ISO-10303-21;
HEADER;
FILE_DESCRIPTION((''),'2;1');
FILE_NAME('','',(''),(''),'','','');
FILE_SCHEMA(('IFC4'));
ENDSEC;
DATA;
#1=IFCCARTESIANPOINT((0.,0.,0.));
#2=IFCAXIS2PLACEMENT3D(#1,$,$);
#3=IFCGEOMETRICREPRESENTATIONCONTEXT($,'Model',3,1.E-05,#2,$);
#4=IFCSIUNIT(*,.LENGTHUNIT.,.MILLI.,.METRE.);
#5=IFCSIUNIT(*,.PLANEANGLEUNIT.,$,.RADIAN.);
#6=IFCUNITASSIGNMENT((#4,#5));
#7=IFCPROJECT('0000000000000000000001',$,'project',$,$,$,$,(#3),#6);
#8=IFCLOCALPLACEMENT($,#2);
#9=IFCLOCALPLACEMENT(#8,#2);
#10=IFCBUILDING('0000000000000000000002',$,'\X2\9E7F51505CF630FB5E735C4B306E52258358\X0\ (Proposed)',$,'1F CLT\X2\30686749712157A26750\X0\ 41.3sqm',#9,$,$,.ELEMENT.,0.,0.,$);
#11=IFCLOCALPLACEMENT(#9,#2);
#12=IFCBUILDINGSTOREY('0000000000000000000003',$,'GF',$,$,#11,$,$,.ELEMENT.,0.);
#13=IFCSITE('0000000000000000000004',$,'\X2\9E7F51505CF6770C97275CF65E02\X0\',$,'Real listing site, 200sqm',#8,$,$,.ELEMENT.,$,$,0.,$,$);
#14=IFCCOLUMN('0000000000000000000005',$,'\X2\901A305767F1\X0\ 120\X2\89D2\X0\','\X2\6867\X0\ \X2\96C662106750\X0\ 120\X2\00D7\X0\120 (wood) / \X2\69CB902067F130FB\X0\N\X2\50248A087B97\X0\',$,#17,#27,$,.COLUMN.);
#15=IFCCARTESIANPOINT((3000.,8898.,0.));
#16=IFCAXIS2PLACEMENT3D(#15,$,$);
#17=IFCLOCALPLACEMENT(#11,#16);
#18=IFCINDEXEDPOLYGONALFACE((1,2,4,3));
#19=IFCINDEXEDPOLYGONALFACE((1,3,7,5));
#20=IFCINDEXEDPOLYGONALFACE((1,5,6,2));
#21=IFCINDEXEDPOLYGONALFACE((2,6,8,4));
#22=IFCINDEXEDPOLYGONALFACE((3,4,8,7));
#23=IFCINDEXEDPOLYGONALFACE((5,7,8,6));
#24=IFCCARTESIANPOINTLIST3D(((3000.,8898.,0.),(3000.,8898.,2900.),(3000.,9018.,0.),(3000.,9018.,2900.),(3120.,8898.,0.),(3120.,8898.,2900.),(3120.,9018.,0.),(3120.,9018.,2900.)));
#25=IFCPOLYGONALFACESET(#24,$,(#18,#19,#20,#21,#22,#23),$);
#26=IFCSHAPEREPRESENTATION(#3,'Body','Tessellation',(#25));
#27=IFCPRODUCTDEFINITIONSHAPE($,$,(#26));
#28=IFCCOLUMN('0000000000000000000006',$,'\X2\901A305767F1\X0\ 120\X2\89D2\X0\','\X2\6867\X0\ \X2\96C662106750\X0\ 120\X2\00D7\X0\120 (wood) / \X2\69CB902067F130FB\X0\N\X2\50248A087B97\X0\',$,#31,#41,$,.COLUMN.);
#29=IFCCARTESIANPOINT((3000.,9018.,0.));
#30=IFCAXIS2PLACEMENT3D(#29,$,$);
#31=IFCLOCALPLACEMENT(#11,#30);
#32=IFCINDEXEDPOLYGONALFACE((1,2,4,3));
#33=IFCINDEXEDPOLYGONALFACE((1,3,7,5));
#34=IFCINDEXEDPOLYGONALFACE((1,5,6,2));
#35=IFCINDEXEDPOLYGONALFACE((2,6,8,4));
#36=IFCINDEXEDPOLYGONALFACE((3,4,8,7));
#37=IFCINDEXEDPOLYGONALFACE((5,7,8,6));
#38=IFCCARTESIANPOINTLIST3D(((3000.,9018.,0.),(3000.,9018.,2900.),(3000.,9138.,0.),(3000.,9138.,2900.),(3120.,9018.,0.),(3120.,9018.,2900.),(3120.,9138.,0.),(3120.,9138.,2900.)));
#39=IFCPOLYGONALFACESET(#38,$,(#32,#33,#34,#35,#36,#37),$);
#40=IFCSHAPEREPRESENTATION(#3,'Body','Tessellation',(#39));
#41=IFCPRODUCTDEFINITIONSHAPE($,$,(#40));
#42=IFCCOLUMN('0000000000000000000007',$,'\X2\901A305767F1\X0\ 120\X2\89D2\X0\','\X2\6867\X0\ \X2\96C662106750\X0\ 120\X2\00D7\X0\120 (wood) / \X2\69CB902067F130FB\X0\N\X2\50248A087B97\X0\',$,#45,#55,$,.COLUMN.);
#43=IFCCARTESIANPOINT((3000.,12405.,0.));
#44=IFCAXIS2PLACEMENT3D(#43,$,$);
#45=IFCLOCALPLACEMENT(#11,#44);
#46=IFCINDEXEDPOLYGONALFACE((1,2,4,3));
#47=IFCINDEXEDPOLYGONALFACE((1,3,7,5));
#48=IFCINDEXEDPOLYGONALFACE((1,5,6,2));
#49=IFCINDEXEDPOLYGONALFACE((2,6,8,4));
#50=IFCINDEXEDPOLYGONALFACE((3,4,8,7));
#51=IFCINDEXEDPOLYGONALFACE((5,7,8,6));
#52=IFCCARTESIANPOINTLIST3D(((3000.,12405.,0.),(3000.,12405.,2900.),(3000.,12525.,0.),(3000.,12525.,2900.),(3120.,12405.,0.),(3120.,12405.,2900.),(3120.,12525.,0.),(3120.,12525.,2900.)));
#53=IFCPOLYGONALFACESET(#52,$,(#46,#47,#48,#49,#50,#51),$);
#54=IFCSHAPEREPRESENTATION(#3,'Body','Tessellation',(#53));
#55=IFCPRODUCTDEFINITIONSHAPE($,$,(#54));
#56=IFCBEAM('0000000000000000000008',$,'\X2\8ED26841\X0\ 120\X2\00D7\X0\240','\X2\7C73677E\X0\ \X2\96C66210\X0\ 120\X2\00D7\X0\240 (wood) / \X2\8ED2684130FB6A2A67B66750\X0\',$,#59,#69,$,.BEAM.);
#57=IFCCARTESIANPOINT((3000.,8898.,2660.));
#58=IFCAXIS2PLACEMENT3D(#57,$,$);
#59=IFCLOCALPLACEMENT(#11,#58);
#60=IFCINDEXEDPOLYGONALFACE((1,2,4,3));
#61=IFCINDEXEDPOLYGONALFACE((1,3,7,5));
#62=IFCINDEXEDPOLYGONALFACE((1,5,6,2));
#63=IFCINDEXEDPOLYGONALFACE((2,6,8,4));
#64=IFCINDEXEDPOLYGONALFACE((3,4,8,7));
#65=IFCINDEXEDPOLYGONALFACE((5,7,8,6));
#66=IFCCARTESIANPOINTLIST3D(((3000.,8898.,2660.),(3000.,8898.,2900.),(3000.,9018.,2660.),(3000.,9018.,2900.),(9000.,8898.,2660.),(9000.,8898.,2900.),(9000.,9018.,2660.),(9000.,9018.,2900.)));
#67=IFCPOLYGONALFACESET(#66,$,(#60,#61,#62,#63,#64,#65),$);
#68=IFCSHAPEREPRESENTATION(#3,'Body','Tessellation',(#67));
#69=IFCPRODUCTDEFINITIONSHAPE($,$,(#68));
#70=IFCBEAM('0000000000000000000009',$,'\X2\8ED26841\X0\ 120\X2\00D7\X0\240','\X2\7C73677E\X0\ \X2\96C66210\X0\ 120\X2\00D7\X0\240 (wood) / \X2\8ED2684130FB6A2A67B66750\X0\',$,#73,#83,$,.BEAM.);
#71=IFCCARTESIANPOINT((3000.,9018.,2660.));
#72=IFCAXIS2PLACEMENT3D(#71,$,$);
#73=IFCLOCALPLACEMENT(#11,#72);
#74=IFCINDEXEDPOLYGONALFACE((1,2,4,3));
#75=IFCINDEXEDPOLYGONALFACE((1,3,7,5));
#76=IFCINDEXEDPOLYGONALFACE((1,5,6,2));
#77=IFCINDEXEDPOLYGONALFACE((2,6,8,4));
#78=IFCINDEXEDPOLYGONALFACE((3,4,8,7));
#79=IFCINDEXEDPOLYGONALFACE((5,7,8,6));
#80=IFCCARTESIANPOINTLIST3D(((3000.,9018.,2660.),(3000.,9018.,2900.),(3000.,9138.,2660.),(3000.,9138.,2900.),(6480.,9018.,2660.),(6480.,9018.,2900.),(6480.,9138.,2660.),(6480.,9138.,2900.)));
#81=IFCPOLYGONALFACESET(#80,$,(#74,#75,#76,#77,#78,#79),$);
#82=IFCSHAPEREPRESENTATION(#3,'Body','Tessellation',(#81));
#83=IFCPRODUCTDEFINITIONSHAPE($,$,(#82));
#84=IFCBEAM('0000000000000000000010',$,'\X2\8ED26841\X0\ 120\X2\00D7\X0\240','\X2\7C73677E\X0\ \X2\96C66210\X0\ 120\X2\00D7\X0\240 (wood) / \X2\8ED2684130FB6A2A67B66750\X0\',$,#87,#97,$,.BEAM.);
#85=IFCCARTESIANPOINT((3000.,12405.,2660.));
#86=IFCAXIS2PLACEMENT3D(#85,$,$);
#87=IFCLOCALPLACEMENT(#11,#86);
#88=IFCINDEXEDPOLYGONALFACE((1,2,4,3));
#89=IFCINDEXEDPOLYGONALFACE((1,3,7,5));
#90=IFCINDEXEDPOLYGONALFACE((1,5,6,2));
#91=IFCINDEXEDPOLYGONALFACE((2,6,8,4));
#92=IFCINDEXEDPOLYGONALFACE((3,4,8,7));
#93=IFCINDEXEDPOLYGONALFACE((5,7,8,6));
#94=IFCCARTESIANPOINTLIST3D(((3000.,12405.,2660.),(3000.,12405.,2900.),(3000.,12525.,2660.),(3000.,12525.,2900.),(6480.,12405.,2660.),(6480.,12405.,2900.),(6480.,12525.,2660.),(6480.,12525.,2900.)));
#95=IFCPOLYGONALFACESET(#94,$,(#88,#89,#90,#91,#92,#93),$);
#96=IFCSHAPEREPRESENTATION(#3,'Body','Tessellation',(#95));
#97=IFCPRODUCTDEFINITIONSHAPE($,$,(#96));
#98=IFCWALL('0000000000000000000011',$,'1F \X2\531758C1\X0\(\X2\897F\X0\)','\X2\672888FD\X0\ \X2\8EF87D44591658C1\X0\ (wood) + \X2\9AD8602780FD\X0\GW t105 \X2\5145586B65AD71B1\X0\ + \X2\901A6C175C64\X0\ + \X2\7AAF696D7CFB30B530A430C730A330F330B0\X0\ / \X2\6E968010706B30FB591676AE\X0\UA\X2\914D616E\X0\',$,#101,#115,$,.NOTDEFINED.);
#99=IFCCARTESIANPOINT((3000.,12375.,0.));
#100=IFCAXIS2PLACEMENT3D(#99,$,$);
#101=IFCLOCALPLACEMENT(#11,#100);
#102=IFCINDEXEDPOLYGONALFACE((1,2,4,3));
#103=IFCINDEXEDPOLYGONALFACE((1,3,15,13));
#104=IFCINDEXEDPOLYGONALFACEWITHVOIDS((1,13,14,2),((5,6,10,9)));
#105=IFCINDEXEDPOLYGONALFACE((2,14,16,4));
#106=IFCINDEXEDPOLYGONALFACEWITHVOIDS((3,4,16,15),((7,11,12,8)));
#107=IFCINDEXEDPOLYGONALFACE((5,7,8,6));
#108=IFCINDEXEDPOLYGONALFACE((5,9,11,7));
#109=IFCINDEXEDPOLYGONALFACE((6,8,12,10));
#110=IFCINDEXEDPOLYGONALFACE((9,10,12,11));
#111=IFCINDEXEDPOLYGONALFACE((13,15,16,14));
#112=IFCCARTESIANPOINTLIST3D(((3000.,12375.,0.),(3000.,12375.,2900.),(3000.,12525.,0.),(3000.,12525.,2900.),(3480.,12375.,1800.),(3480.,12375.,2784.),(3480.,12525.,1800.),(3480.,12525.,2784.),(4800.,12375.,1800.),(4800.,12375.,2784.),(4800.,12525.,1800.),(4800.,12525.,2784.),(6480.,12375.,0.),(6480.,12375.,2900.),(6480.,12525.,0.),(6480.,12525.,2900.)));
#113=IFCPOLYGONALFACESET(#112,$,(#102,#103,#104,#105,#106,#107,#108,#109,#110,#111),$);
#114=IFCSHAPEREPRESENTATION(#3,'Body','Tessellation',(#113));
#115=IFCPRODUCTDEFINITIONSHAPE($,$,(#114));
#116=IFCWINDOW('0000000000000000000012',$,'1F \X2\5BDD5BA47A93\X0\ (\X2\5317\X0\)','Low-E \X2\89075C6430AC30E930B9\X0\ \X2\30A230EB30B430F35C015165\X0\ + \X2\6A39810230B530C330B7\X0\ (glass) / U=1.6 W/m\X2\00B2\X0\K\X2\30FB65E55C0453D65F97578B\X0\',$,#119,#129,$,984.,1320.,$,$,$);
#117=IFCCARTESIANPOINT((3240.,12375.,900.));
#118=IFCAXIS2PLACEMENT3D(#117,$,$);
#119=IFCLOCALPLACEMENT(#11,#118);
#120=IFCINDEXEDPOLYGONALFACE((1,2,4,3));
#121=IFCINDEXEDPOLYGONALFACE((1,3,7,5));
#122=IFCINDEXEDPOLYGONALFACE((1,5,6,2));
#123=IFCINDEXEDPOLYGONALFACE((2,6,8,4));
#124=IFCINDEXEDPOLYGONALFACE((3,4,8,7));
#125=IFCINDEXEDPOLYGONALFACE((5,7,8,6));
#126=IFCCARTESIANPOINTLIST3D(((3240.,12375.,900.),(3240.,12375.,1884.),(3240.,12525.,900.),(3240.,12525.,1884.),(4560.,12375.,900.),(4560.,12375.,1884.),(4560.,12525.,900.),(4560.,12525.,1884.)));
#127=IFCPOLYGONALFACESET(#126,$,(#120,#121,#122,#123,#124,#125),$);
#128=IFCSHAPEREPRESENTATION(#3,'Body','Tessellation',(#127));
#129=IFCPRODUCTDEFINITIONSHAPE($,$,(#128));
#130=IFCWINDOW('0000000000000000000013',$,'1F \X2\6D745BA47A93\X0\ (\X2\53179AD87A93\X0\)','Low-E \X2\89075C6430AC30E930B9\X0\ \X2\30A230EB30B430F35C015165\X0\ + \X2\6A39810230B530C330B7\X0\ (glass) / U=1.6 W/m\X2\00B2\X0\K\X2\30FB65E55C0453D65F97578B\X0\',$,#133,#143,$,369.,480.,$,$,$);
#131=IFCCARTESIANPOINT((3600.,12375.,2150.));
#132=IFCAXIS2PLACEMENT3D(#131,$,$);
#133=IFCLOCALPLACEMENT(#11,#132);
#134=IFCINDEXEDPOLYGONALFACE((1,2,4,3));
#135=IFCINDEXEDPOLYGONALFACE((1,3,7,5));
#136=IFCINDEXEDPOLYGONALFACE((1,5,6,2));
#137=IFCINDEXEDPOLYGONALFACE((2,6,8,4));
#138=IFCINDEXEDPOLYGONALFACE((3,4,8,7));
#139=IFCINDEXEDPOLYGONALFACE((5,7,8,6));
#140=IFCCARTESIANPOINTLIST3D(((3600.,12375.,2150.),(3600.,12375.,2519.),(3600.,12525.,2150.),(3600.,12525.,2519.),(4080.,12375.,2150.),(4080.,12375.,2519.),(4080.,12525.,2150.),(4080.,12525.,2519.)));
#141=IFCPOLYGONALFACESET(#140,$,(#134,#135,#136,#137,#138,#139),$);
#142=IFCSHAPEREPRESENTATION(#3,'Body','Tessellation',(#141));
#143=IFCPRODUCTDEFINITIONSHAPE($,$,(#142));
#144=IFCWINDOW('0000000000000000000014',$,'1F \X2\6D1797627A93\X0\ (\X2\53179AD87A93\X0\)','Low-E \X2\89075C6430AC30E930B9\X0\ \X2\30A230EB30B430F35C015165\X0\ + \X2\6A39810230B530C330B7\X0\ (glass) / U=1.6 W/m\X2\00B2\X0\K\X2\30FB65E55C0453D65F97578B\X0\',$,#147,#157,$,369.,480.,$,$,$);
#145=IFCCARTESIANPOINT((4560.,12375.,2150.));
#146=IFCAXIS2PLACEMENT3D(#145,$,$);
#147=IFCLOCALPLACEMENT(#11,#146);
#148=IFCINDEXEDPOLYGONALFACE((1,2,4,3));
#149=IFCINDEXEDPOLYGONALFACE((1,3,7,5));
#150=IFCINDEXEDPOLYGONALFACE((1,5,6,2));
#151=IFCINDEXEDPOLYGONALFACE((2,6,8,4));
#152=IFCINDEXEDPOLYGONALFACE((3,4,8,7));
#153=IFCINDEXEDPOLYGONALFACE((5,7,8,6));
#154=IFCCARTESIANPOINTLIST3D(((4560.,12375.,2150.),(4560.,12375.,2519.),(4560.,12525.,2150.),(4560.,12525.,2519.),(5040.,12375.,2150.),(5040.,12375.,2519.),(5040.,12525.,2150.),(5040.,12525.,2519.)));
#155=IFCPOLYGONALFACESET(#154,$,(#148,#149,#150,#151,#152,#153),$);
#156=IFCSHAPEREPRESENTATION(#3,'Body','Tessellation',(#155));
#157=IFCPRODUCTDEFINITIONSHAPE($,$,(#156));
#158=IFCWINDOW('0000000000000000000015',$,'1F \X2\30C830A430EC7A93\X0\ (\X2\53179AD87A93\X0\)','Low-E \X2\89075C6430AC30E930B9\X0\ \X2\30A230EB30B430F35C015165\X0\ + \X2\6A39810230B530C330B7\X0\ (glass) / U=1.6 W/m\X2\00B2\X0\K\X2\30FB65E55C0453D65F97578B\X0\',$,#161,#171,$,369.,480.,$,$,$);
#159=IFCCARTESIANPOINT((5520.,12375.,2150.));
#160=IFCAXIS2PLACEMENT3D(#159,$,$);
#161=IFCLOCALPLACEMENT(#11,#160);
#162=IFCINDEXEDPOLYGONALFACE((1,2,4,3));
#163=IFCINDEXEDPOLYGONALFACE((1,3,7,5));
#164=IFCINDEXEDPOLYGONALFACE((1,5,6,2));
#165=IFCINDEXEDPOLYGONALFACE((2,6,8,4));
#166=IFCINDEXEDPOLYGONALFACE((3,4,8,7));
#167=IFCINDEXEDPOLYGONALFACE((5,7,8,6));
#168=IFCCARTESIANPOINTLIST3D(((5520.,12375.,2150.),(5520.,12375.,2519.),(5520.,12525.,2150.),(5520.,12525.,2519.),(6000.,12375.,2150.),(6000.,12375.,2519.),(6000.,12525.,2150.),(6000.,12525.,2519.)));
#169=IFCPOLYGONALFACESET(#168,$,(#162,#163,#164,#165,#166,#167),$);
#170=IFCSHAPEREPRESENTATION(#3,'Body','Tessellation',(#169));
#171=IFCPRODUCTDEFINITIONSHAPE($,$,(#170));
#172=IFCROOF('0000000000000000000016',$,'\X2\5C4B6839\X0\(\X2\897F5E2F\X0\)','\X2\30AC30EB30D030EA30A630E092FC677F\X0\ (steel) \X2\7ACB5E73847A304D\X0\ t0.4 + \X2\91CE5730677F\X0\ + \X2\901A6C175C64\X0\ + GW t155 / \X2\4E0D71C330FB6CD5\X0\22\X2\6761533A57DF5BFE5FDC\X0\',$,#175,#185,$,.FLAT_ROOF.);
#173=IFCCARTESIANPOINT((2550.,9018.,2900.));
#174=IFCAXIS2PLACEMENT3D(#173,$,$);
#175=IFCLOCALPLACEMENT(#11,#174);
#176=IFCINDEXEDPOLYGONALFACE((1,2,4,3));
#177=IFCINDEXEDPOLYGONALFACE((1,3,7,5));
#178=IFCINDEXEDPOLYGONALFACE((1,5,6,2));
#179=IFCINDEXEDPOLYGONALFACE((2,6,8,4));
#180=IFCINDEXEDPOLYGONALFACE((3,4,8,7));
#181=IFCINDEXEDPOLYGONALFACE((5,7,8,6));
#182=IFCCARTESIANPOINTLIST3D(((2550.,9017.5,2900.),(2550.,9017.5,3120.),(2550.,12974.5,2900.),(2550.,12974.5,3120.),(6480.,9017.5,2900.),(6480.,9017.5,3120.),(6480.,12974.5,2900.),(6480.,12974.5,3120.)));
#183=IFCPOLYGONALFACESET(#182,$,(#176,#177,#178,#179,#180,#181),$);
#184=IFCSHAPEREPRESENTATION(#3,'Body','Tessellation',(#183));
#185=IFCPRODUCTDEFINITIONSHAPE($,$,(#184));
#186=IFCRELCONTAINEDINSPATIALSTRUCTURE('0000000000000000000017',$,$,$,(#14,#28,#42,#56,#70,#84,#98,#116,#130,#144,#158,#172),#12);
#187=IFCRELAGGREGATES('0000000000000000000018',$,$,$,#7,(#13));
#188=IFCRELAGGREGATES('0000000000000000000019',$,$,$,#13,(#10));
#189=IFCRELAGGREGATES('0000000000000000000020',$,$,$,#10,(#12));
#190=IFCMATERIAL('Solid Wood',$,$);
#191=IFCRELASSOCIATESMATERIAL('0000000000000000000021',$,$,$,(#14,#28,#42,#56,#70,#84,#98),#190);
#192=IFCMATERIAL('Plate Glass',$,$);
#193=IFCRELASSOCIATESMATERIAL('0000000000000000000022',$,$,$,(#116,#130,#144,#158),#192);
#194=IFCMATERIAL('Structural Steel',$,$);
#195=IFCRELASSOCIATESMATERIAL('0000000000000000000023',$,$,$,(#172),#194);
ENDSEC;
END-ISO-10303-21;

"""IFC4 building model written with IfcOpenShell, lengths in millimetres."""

from ifc_helpers import new_model, si_unit, frame, frame_2d, origin, place, context, project, spatial, rectangle, extrude, material, element, fill, save


model = new_model("IFC4")

# Units and contexts
model_context = context("Model", 3, precision=1e-05, world=origin())
ifc_project = project(units=[si_unit("LENGTHUNIT", "METRE", prefix="MILLI"), si_unit("PLANEANGLEUNIT", "RADIAN")], contexts=[model_context])

# Site, building, storey
site_placement = place(None, origin())
site = spatial("IfcSite", under=ifc_project, at=site_placement, Name="鹿児島県霧島市", ObjectType="Real listing site, 200sqm", CompositionType="ELEMENT", RefElevation=0.0)
building_placement = place(site_placement, origin())
building = spatial("IfcBuilding", under=site, at=building_placement, Name="鹿児島・平屋の別荘 (Proposed)", ObjectType="1F CLTと杉無垢材 41.3sqm", CompositionType="ELEMENT", ElevationOfRefHeight=0.0, ElevationOfTerrain=0.0)
storey_placement = place(building_placement, origin())
storey = spatial("IfcBuildingStorey", under=building, at=storey_placement, Name="GF", CompositionType="ELEMENT", Elevation=0.0)

# Columns
ifc_material_1 = material(Name="Solid Wood")
column_1_placement = place(storey_placement, frame((3000.0, 8898.0, 0.0)))
element("IfcColumn", 1, at=column_1_placement, inside=storey, material=ifc_material_1, Name="通し柱 120角", Description="桧 集成材 120×120 (wood) / 構造柱・N値計算", PredefinedType="COLUMN", context=model_context, shape_type="SweptSolid", body=[
    extrude(rectangle(XDim=120.0, YDim=120.0, at=frame_2d((60.0, 60.0))), frame((3000.0, 8898.0, 0.0)), (0.0, 0.0, 1.0), 2900.0),
])
column_2_placement = place(storey_placement, frame((3000.0, 9018.0, 0.0)))
element("IfcColumn", 2, at=column_2_placement, inside=storey, material=ifc_material_1, Name="通し柱 120角", Description="桧 集成材 120×120 (wood) / 構造柱・N値計算", PredefinedType="COLUMN", context=model_context, shape_type="SweptSolid", body=[
    extrude(rectangle(XDim=120.0, YDim=120.0, at=frame_2d((60.0, 60.0))), frame((3000.0, 9018.0, 0.0)), (0.0, 0.0, 1.0), 2900.0),
])
column_3_placement = place(storey_placement, frame((3000.0, 12405.0, 0.0)))
element("IfcColumn", 3, at=column_3_placement, inside=storey, material=ifc_material_1, Name="通し柱 120角", Description="桧 集成材 120×120 (wood) / 構造柱・N値計算", PredefinedType="COLUMN", context=model_context, shape_type="SweptSolid", body=[
    extrude(rectangle(XDim=120.0, YDim=120.0, at=frame_2d((60.0, 60.0))), frame((3000.0, 12405.0, 0.0)), (0.0, 0.0, 1.0), 2900.0),
])

# Beams
beam_1_placement = place(storey_placement, frame((3000.0, 8898.0, 2660.0)))
element("IfcBeam", 4, at=beam_1_placement, inside=storey, material=ifc_material_1, Name="軒桁 120×240", Description="米松 集成 120×240 (wood) / 軒桁・横架材", PredefinedType="BEAM", context=model_context, shape_type="SweptSolid", body=[
    extrude(rectangle(XDim=6000.0, YDim=120.0, at=frame_2d((3000.0, 60.0))), frame((3000.0, 8898.0, 2660.0)), (0.0, 0.0, 1.0), 240.0),
])
beam_2_placement = place(storey_placement, frame((3000.0, 9018.0, 2660.0)))
element("IfcBeam", 5, at=beam_2_placement, inside=storey, material=ifc_material_1, Name="軒桁 120×240", Description="米松 集成 120×240 (wood) / 軒桁・横架材", PredefinedType="BEAM", context=model_context, shape_type="SweptSolid", body=[
    extrude(rectangle(XDim=3480.0, YDim=120.0, at=frame_2d((1740.0, 60.0))), frame((3000.0, 9018.0, 2660.0)), (0.0, 0.0, 1.0), 240.0),
])
beam_3_placement = place(storey_placement, frame((3000.0, 12405.0, 2660.0)))
element("IfcBeam", 6, at=beam_3_placement, inside=storey, material=ifc_material_1, Name="軒桁 120×240", Description="米松 集成 120×240 (wood) / 軒桁・横架材", PredefinedType="BEAM", context=model_context, shape_type="SweptSolid", body=[
    extrude(rectangle(XDim=3480.0, YDim=120.0, at=frame_2d((1740.0, 60.0))), frame((3000.0, 12405.0, 2660.0)), (0.0, 0.0, 1.0), 240.0),
])

# Wall, openings, windows
wall_1_placement = place(storey_placement, frame((3000.0, 12375.0, 0.0)))
wall_1 = element("IfcWall", 7, at=wall_1_placement, inside=storey, material=ifc_material_1, Name="1F 北壁(西)", Description="木製 軸組外壁 (wood) + 高性能GW t105 充填断熱 + 通気層 + 窯業系サイディング / 準耐火・外皮UA配慮", PredefinedType="NOTDEFINED", context=model_context, shape_type="SweptSolid", body=[
    extrude(rectangle(XDim=3480.0, YDim=150.0, at=frame_2d((1740.0, 75.0))), frame((3000.0, 12375.0, 0.0)), (0.0, 0.0, 1.0), 2900.0),
])
opening_1_placement = place(storey_placement, frame((3240.0, 12375.0, 900.0)))
opening_1 = element("IfcOpeningElement", 8, at=opening_1_placement, cuts=wall_1, PredefinedType="NOTDEFINED", context=model_context, shape_type="SweptSolid", body=[
    extrude(rectangle(XDim=1320.0, YDim=150.0, at=frame_2d((660.0, 75.0))), frame((3240.0, 12375.0, 900.0)), (0.0, 0.0, 1.0), 984.0),
])
opening_2_placement = place(storey_placement, frame((3600.0, 12375.0, 2150.0)))
opening_2 = element("IfcOpeningElement", 9, at=opening_2_placement, cuts=wall_1, PredefinedType="NOTDEFINED", context=model_context, shape_type="SweptSolid", body=[
    extrude(rectangle(XDim=480.0, YDim=150.0, at=frame_2d((240.0, 75.0))), frame((3600.0, 12375.0, 2150.0)), (0.0, 0.0, 1.0), 369.0),
])
opening_3_placement = place(storey_placement, frame((4560.0, 12375.0, 2150.0)))
opening_3 = element("IfcOpeningElement", 10, at=opening_3_placement, cuts=wall_1, PredefinedType="NOTDEFINED", context=model_context, shape_type="SweptSolid", body=[
    extrude(rectangle(XDim=480.0, YDim=150.0, at=frame_2d((240.0, 75.0))), frame((4560.0, 12375.0, 2150.0)), (0.0, 0.0, 1.0), 369.0),
])
opening_4_placement = place(storey_placement, frame((5520.0, 12375.0, 2150.0)))
opening_4 = element("IfcOpeningElement", 11, at=opening_4_placement, cuts=wall_1, PredefinedType="NOTDEFINED", context=model_context, shape_type="SweptSolid", body=[
    extrude(rectangle(XDim=480.0, YDim=150.0, at=frame_2d((240.0, 75.0))), frame((5520.0, 12375.0, 2150.0)), (0.0, 0.0, 1.0), 369.0),
])
ifc_material_2 = material(Name="Plate Glass")
window_1_placement = place(storey_placement, frame((3240.0, 12375.0, 900.0)))
window_1 = element("IfcWindow", 12, at=window_1_placement, inside=storey, material=ifc_material_2, Name="1F 寝室窓 (北)", Description="Low-E 複層ガラス アルゴン封入 + 樹脂サッシ (glass) / U=1.6 W/m²K・日射取得型", OverallHeight=984.0, OverallWidth=1320.0, context=model_context, shape_type="SweptSolid", body=[
    extrude(rectangle(XDim=1320.0, YDim=150.0, at=frame_2d((660.0, 75.0))), frame((3240.0, 12375.0, 900.0)), (0.0, 0.0, 1.0), 984.0),
])
fill(opening_1, window_1)
window_2_placement = place(storey_placement, frame((3600.0, 12375.0, 2150.0)))
window_2 = element("IfcWindow", 13, at=window_2_placement, inside=storey, material=ifc_material_2, Name="1F 浴室窓 (北高窓)", Description="Low-E 複層ガラス アルゴン封入 + 樹脂サッシ (glass) / U=1.6 W/m²K・日射取得型", OverallHeight=369.0, OverallWidth=480.0, context=model_context, shape_type="SweptSolid", body=[
    extrude(rectangle(XDim=480.0, YDim=150.0, at=frame_2d((240.0, 75.0))), frame((3600.0, 12375.0, 2150.0)), (0.0, 0.0, 1.0), 369.0),
])
fill(opening_2, window_2)
window_3_placement = place(storey_placement, frame((4560.0, 12375.0, 2150.0)))
window_3 = element("IfcWindow", 14, at=window_3_placement, inside=storey, material=ifc_material_2, Name="1F 洗面窓 (北高窓)", Description="Low-E 複層ガラス アルゴン封入 + 樹脂サッシ (glass) / U=1.6 W/m²K・日射取得型", OverallHeight=369.0, OverallWidth=480.0, context=model_context, shape_type="SweptSolid", body=[
    extrude(rectangle(XDim=480.0, YDim=150.0, at=frame_2d((240.0, 75.0))), frame((4560.0, 12375.0, 2150.0)), (0.0, 0.0, 1.0), 369.0),
])
fill(opening_3, window_3)
window_4_placement = place(storey_placement, frame((5520.0, 12375.0, 2150.0)))
window_4 = element("IfcWindow", 15, at=window_4_placement, inside=storey, material=ifc_material_2, Name="1F トイレ窓 (北高窓)", Description="Low-E 複層ガラス アルゴン封入 + 樹脂サッシ (glass) / U=1.6 W/m²K・日射取得型", OverallHeight=369.0, OverallWidth=480.0, context=model_context, shape_type="SweptSolid", body=[
    extrude(rectangle(XDim=480.0, YDim=150.0, at=frame_2d((240.0, 75.0))), frame((5520.0, 12375.0, 2150.0)), (0.0, 0.0, 1.0), 369.0),
])
fill(opening_4, window_4)

# Roof
ifc_material_3 = material(Name="Structural Steel")
roof_placement = place(storey_placement, frame((2550.0, 9018.0, 2900.0)))
element("IfcRoof", 16, at=roof_placement, inside=storey, material=ifc_material_3, Name="屋根(西帯)", Description="ガルバリウム鋼板 (steel) 立平葺き t0.4 + 野地板 + 通気層 + GW t155 / 不燃・法22条区域対応", PredefinedType="FLAT_ROOF", context=model_context, shape_type="SweptSolid", body=[
    extrude(rectangle(XDim=3930.0, YDim=3957.0, at=frame_2d((1965.0, 1978.0))), frame((2550.0, 9018.0, 2900.0)), (0.0, 0.0, 1.0), 220.0),
])

save(model, "model.ifc")
